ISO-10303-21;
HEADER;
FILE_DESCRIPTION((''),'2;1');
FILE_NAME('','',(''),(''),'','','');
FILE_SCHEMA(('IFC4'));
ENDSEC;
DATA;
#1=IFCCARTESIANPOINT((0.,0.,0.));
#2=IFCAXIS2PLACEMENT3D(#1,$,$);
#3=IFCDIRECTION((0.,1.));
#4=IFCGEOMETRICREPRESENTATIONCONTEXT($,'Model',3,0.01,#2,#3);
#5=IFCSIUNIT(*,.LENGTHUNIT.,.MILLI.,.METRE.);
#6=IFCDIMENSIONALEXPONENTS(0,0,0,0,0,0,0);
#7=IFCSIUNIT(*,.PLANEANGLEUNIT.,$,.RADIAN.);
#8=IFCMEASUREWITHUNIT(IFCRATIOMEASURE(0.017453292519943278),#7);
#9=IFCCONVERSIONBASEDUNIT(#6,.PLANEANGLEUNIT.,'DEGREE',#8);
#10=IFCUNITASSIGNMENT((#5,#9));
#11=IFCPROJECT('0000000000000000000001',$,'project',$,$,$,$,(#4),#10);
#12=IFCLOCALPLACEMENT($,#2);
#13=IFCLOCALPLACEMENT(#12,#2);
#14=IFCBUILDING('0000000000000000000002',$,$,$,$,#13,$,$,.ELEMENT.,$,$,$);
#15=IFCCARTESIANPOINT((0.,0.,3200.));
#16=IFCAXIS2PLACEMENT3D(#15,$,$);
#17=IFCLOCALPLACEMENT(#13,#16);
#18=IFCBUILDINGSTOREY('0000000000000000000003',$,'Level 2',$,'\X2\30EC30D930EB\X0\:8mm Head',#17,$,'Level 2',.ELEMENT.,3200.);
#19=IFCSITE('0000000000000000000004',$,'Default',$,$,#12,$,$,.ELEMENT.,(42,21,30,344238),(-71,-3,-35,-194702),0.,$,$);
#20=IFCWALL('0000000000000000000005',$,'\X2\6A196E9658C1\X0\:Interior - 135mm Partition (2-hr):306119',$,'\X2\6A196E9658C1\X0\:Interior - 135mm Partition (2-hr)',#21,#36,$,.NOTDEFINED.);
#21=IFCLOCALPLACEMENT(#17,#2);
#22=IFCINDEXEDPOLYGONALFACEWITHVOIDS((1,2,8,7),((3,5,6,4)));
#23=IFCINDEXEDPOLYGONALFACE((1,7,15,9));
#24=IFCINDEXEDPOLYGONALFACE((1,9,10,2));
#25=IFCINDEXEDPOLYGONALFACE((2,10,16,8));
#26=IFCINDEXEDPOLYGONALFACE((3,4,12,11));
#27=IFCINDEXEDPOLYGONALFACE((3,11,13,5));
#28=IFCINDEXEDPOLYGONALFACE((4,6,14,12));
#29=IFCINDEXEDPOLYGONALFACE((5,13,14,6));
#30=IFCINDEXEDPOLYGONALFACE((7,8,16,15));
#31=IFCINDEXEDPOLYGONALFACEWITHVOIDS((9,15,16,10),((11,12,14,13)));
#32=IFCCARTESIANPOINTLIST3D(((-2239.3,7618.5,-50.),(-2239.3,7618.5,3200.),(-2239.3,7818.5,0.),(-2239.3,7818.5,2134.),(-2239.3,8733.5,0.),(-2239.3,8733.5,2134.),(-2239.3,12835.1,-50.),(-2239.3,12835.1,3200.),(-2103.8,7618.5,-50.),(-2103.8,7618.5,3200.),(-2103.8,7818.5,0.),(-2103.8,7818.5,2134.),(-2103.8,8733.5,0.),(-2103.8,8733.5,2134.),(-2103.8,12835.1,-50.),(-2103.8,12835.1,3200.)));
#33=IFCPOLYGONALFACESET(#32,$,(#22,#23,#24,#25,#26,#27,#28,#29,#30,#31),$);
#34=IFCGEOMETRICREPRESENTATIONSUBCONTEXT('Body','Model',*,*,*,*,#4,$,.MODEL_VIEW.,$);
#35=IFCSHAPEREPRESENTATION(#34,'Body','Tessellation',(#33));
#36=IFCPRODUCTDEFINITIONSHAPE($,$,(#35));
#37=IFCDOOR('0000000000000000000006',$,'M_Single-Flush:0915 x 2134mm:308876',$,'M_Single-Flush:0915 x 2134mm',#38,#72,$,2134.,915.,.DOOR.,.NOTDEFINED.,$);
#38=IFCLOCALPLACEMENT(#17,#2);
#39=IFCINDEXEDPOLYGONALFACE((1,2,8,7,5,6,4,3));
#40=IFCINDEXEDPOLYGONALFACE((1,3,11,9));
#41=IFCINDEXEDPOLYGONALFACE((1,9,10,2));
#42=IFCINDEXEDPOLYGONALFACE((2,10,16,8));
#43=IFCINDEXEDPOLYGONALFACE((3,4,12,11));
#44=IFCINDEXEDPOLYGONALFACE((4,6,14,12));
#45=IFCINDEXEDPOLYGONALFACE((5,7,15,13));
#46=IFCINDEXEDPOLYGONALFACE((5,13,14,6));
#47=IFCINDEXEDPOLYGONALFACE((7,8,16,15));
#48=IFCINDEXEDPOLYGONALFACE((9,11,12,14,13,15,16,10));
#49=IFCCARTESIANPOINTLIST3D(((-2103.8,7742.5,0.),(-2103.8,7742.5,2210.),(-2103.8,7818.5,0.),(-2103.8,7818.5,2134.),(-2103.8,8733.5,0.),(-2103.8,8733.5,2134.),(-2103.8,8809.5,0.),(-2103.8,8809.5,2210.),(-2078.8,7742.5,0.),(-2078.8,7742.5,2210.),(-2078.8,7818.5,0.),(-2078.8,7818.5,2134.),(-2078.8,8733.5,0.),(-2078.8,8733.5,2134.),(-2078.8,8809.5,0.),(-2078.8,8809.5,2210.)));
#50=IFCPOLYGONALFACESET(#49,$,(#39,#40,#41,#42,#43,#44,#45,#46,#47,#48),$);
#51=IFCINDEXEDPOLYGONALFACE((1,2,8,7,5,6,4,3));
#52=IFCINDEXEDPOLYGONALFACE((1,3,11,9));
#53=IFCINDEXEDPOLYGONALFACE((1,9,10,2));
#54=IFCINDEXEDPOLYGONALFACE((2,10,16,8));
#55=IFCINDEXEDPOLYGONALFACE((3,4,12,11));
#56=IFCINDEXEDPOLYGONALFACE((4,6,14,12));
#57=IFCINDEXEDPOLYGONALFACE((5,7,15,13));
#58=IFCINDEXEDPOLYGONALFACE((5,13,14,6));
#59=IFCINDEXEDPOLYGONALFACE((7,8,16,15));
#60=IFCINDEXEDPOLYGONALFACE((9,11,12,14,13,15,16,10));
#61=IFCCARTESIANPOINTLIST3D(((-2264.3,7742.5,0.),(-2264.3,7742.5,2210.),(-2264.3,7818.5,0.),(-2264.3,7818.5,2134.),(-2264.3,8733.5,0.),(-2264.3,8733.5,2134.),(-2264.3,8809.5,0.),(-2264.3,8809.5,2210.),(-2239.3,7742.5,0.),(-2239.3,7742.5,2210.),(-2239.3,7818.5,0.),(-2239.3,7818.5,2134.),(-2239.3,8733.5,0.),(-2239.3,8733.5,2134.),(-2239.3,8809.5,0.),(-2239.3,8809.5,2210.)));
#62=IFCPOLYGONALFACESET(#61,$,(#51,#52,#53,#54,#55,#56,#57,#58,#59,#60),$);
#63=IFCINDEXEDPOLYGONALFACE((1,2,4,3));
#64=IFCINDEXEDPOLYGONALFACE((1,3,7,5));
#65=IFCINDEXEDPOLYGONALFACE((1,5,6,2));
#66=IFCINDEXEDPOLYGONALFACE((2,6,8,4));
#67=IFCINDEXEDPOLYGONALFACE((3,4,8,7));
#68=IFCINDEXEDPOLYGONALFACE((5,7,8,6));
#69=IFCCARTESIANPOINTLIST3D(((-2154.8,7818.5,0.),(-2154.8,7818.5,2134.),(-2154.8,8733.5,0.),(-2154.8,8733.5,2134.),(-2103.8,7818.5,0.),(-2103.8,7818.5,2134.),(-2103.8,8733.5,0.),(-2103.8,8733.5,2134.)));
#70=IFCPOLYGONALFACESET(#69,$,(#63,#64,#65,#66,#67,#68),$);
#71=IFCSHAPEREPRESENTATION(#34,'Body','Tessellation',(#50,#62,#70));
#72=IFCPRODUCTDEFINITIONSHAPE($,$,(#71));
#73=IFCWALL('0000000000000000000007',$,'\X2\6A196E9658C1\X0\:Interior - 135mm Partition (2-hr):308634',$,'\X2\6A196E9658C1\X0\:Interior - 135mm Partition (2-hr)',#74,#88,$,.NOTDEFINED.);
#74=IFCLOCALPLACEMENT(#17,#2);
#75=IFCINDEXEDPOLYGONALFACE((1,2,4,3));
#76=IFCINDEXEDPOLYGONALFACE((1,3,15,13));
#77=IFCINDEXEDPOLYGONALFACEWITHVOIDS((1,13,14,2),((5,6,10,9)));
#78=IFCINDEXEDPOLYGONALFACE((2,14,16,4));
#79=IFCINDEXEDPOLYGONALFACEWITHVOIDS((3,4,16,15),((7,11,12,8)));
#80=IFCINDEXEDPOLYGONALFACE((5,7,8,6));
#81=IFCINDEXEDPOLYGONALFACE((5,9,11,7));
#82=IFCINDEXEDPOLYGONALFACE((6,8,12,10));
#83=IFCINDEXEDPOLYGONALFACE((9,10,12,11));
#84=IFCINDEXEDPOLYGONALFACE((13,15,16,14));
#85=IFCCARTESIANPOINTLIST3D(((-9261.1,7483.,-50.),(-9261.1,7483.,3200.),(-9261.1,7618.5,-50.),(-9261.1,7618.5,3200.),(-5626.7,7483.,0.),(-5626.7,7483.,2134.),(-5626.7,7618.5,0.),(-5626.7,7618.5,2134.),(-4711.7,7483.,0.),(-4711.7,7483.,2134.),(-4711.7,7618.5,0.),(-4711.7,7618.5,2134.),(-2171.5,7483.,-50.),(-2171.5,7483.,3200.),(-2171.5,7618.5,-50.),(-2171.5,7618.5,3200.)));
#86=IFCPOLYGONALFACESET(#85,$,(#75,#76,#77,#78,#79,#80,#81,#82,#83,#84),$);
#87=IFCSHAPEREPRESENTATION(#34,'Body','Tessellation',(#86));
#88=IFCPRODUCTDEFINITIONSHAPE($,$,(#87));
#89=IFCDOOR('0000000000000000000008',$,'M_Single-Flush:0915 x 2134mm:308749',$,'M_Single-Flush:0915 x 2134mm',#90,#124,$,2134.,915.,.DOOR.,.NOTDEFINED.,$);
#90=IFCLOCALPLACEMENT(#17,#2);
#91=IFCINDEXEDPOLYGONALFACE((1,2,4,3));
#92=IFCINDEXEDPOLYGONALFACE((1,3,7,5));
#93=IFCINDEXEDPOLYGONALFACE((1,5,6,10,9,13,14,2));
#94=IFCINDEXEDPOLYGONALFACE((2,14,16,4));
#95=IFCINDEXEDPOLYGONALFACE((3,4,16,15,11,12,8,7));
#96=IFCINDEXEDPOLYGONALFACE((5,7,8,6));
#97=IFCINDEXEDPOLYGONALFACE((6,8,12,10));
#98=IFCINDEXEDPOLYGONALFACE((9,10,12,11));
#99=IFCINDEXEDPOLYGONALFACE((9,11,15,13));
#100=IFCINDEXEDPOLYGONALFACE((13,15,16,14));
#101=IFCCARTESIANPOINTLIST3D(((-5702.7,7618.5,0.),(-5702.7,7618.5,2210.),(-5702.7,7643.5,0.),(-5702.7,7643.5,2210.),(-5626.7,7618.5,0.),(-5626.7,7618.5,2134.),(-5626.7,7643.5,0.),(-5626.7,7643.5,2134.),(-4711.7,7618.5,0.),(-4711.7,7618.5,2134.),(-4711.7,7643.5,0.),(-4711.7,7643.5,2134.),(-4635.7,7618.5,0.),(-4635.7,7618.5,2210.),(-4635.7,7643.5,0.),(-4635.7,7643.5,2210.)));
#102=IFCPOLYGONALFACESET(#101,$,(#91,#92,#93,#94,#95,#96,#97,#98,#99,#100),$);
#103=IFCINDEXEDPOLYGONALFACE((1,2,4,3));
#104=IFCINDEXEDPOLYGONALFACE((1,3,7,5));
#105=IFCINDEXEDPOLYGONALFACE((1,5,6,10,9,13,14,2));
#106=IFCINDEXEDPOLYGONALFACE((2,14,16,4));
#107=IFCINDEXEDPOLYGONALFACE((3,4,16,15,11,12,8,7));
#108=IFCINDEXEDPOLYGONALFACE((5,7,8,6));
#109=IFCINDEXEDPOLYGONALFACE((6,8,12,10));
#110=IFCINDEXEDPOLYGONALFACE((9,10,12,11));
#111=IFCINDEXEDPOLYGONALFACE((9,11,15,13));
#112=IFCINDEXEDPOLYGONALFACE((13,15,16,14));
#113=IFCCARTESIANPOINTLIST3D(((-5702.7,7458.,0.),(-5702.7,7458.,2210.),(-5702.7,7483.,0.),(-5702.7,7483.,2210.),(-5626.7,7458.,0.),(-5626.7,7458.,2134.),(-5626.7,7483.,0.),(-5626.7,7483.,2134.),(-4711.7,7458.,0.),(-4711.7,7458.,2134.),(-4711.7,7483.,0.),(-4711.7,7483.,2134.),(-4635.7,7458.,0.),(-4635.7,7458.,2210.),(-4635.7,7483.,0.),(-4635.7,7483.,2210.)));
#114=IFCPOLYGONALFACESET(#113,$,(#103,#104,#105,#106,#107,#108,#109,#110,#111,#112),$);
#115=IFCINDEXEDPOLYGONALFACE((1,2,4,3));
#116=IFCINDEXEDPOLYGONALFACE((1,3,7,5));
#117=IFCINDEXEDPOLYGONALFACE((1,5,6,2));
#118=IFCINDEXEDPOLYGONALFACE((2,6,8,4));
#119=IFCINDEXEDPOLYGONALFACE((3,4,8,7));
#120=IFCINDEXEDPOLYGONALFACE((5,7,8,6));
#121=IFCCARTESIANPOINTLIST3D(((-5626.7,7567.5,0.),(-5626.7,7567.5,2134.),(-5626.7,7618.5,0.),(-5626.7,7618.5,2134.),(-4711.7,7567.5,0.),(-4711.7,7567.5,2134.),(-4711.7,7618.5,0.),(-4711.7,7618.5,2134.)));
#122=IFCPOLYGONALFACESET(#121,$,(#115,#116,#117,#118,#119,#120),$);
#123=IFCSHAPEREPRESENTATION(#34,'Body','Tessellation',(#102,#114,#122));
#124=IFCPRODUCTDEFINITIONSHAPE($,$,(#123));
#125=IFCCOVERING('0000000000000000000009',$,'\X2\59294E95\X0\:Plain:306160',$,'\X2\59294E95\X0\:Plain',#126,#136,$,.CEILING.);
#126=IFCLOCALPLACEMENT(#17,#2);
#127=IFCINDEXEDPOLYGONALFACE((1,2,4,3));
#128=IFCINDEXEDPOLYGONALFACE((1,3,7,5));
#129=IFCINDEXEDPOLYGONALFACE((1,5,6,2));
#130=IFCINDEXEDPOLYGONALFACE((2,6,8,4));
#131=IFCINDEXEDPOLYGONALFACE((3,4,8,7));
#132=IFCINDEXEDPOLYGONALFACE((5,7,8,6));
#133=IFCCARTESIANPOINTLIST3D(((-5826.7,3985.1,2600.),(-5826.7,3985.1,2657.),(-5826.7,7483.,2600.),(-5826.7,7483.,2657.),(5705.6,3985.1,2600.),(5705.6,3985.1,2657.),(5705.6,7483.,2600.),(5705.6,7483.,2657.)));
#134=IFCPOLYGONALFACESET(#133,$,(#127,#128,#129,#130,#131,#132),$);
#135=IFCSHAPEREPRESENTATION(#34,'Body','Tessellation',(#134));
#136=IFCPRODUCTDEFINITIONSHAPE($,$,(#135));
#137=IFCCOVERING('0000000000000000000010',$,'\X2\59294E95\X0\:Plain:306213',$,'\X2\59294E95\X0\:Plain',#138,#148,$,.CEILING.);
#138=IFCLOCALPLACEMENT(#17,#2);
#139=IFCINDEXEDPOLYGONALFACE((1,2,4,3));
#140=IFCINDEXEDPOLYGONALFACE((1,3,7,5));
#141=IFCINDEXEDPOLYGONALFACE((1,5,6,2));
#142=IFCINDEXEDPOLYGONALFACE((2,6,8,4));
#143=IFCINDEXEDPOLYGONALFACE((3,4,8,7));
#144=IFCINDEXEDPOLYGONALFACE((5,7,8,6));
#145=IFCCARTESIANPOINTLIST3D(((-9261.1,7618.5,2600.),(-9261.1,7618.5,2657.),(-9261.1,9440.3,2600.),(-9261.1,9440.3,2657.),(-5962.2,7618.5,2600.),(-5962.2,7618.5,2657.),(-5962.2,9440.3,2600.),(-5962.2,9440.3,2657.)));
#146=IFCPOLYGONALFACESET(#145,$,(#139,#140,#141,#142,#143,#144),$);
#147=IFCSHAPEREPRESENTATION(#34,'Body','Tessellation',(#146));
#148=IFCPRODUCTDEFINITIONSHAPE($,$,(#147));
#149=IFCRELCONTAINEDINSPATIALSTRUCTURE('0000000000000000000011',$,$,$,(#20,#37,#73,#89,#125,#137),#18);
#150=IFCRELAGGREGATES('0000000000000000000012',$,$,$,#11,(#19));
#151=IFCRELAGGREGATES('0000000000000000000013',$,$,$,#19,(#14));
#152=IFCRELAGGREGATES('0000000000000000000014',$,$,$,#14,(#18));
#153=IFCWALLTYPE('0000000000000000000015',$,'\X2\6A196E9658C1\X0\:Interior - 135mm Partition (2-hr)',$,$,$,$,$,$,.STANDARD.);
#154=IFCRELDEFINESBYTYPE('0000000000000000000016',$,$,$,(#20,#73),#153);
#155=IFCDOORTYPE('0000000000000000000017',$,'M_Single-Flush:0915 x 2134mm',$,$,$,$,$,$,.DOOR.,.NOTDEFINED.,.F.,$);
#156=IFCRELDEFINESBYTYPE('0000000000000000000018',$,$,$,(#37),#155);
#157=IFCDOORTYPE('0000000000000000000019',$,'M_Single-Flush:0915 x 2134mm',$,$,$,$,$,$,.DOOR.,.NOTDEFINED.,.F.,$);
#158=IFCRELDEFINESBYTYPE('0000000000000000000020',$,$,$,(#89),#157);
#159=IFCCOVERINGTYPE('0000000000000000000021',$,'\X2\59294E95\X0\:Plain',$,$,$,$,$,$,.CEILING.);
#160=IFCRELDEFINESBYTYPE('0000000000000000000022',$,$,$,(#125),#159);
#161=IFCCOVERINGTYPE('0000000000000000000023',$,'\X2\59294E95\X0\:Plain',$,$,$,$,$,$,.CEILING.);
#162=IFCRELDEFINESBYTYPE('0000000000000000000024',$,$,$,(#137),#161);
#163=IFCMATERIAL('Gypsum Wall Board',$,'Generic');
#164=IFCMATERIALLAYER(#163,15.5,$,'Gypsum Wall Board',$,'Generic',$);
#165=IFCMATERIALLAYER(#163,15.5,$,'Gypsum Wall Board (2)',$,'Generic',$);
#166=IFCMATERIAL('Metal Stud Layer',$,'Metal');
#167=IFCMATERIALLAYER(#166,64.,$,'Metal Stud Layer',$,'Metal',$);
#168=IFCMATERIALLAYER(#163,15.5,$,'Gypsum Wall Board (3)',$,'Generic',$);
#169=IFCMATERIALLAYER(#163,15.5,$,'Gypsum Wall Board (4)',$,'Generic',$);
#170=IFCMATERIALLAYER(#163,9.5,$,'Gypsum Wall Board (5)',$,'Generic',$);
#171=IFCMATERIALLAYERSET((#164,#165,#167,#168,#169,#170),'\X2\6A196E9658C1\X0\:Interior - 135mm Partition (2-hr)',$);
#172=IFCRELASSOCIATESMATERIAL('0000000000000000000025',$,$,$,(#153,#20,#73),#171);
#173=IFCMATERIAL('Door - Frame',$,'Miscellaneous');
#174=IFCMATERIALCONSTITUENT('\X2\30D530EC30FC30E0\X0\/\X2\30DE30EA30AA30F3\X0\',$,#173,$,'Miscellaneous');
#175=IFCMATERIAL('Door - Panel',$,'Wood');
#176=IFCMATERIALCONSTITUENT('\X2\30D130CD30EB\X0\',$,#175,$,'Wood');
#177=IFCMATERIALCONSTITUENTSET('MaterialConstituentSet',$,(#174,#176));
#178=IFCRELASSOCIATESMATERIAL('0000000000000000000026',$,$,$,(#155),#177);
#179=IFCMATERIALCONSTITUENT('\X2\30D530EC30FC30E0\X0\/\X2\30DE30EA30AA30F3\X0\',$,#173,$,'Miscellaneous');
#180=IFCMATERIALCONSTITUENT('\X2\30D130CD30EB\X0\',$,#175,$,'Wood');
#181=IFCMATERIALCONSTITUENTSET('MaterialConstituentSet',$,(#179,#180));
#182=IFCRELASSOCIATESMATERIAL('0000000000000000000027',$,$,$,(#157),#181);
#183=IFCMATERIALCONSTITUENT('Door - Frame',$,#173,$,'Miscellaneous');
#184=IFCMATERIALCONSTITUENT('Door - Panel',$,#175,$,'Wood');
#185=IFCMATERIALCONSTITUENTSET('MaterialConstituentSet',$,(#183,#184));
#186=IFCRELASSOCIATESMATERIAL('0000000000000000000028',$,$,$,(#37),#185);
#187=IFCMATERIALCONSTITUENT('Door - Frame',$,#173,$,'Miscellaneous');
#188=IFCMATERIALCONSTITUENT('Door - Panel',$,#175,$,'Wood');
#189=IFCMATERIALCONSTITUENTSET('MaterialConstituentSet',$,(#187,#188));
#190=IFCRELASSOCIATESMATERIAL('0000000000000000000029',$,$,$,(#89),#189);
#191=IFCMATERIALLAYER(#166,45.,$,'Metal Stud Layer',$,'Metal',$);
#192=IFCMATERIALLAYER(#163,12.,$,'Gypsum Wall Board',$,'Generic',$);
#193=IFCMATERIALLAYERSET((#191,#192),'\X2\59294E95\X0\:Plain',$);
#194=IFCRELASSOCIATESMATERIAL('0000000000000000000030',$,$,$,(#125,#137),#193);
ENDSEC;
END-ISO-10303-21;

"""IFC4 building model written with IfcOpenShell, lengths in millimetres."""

from ifc_helpers import new_model, entity, si_unit, converted_unit, direction, frame, frame_2d, origin, place, context, subcontext, project, spatial, polyline, rectangle, outline, extrude, source, transform, mapped, material, layer, layer_set, layer_usage, constituent, constituent_set, type_object, type_shapes, element, fill, save


model = new_model("IFC4")

# Units and contexts
model_context = context("Model", 3, precision=0.01, world=origin(), true_north=direction((0.0, 1.0)))
body_context = subcontext(model_context, "Body", "Model", "MODEL_VIEW")
ifc_project = project(units=[si_unit("LENGTHUNIT", "METRE", prefix="MILLI"), converted_unit("PLANEANGLEUNIT", "DEGREE", entity("IfcRatioMeasure", 0.017453292519943278), si_unit("PLANEANGLEUNIT", "RADIAN"), dimensions=[0, 0, 0, 0, 0, 0, 0])], contexts=[model_context])

# Site, building, storey
site_placement = place(None, origin())
site = spatial("IfcSite", under=ifc_project, at=site_placement, Name="Default", CompositionType="ELEMENT", RefLatitude=(42, 21, 30, 344238), RefLongitude=(-71, -3, -35, -194702), RefElevation=0.0)
building_placement = place(site_placement, origin())
building = spatial("IfcBuilding", under=site, at=building_placement, CompositionType="ELEMENT")
storey_placement = place(building_placement, frame((0.0, 0.0, 3200.0)))
storey = spatial("IfcBuildingStorey", under=building, at=storey_placement, Name="Level 2", ObjectType="レベル:8mm Head", LongName="Level 2", CompositionType="ELEMENT", Elevation=3200.0)

# Shared definitions
ifc_material_1 = material(Name="Gypsum Wall Board", Category="Generic")
ifc_layer_1 = layer(ifc_material_1, 15.5, Name="Gypsum Wall Board", Category="Generic")
ifc_layer_2 = layer(ifc_material_1, 15.5, Name="Gypsum Wall Board (2)", Category="Generic")
ifc_material_2 = material(Name="Metal Stud Layer", Category="Metal")
ifc_layer_3 = layer(ifc_material_2, 64.0, Name="Metal Stud Layer", Category="Metal")
ifc_layer_4 = layer(ifc_material_1, 15.5, Name="Gypsum Wall Board (3)", Category="Generic")
ifc_layer_5 = layer(ifc_material_1, 15.5, Name="Gypsum Wall Board (4)", Category="Generic")
ifc_layer_6 = layer(ifc_material_1, 9.5, Name="Gypsum Wall Board (5)", Category="Generic")
ifc_layer_set_1 = layer_set([ifc_layer_1, ifc_layer_2, ifc_layer_3, ifc_layer_4, ifc_layer_5, ifc_layer_6], Name="標準壁:Interior - 135mm Partition (2-hr)")
wall_type = type_object("IfcWallType", Name="標準壁:Interior - 135mm Partition (2-hr)", PredefinedType="STANDARD", material=ifc_layer_set_1)
ifc_material_3 = material(Name="Door - Frame", Category="Miscellaneous")
ifc_material_4 = material(Name="Door - Panel", Category="Wood")
ifc_constituent_1 = constituent(ifc_material_3, Name="フレーム/マリオン", Category="Miscellaneous")
ifc_constituent_2 = constituent(ifc_material_4, Name="パネル", Category="Wood")
ifc_constituent_set_1 = constituent_set(constituents=[ifc_constituent_1, ifc_constituent_2], Name="MaterialConstituentSet")
door_type_1 = type_object("IfcDoorType", Name="M_Single-Flush:0915 x 2134mm", OperationType="NOTDEFINED", ParameterTakesPrecedence=False, PredefinedType="DOOR", material=ifc_constituent_set_1)
shared_shape_1 = source(origin(), body_context, "Body", "SweptSolid", [
    extrude(outline(polyline([(-533.5, -1124.0), (533.5, -1124.0), (533.5, 1086.0), (457.5, 1086.0), (457.5, -1048.0), (-457.5, -1048.0), (-457.5, 1086.0), (-533.5, 1086.0), (-533.5, -1124.0)])), frame((457.5, 135.5, 1086.0), z_axis=(0.0, 1.0, 0.0), x_axis=(1.0, 0.0, 0.0)), (0.0, 0.0, 1.0), 25.0),
    extrude(outline(polyline([(-1124.0, -533.5), (1086.0, -533.5), (1086.0, -457.5), (-1048.0, -457.5), (-1048.0, 457.5), (1086.0, 457.5), (1086.0, 533.5), (-1124.0, 533.5), (-1124.0, -533.5)])), frame((457.5, -25.0, 1086.0), z_axis=(0.0, 1.0, 0.0), x_axis=(0.0, 0.0, -1.0)), (0.0, 0.0, 1.0), 25.0),
    extrude(rectangle(XDim=51.0, YDim=915.0, at=frame_2d((0.0, 0.0), x_axis=(1.0, 0.0))), frame((457.5, 110.0, 0.0), z_axis=(0.0, 0.0, 1.0), x_axis=(0.0, 1.0, 0.0)), (0.0, 0.0, 1.0), 2134.0),
])
type_shapes(door_type_1, [shared_shape_1])
ifc_constituent_3 = constituent(ifc_material_3, Name="フレーム/マリオン", Category="Miscellaneous")
ifc_constituent_4 = constituent(ifc_material_4, Name="パネル", Category="Wood")
ifc_constituent_set_2 = constituent_set(constituents=[ifc_constituent_3, ifc_constituent_4], Name="MaterialConstituentSet")
door_type_2 = type_object("IfcDoorType", Name="M_Single-Flush:0915 x 2134mm", OperationType="NOTDEFINED", ParameterTakesPrecedence=False, PredefinedType="DOOR", material=ifc_constituent_set_2)
shared_shape_2 = source(origin(), body_context, "Body", "SweptSolid", [
    extrude(outline(polyline([(-533.5, -1124.0), (533.5, -1124.0), (533.5, 1086.0), (457.5, 1086.0), (457.5, -1048.0), (-457.5, -1048.0), (-457.5, 1086.0), (-533.5, 1086.0), (-533.5, -1124.0)])), frame((457.5, 160.5, 1086.0), z_axis=(0.0, -1.0, 0.0), x_axis=(-1.0, 0.0, 0.0)), (0.0, 0.0, 1.0), 25.0),
    extrude(outline(polyline([(-1124.0, -533.5), (1086.0, -533.5), (1086.0, -457.5), (-1048.0, -457.5), (-1048.0, 457.5), (1086.0, 457.5), (1086.0, 533.5), (-1124.0, 533.5), (-1124.0, -533.5)])), frame((457.5, 0.0, 1086.0), z_axis=(0.0, -1.0, 0.0), x_axis=(0.0, 0.0, -1.0)), (0.0, 0.0, 1.0), 25.0),
    extrude(rectangle(XDim=915.0, YDim=51.0, at=frame_2d((0.0, 0.0), x_axis=(1.0, 0.0))), frame((457.5, 110.0, 0.0)), (0.0, 0.0, 1.0), 2134.0),
])
type_shapes(door_type_2, [shared_shape_2])

# Walls, openings, doors
ifc_layer_usage_1 = layer_usage(ifc_layer_set_1, "AXIS2", "NEGATIVE", 67.8)
wall_1_placement = place(storey_placement, frame((-2171.5, 12835.1, -50.0), z_axis=(0.0, 0.0, 1.0), x_axis=(0.0, -1.0, 0.0)))
wall_1 = element("IfcWall", 1, at=wall_1_placement, inside=storey, type_object=wall_type, material=ifc_layer_usage_1, Name="標準壁:Interior - 135mm Partition (2-hr):306119", ObjectType="標準壁:Interior - 135mm Partition (2-hr)", PredefinedType="NOTDEFINED", context=body_context, shape_type="SweptSolid", body=[
    extrude(rectangle(XDim=5216.6, YDim=135.5, at=frame_2d((2608.3, 0.0), x_axis=(-1.0, 0.0))), origin(), (0.0, 0.0, 1.0), 3250.0),
])
opening_1_placement = place(wall_1_placement, frame((4101.6, -67.8, 50.0)))
opening_1 = element("IfcOpeningElement", 2, at=opening_1_placement, cuts=wall_1, PredefinedType="OPENING", context=body_context, shape_type="SweptSolid", body=[
    extrude(rectangle(XDim=915.0, YDim=2134.0, at=frame_2d((1067.0, 457.5), x_axis=(0.0, 1.0))), frame((0.0, 0.0, 0.0), z_axis=(0.0, 1.0, 0.0), x_axis=(0.0, 0.0, 1.0)), (0.0, 0.0, 1.0), 135.5),
])
ifc_constituent_5 = constituent(ifc_material_3, Name="Door - Frame", Category="Miscellaneous")
ifc_constituent_6 = constituent(ifc_material_4, Name="Door - Panel", Category="Wood")
ifc_constituent_set_3 = constituent_set(constituents=[ifc_constituent_5, ifc_constituent_6], Name="MaterialConstituentSet")
door_1_placement = place(opening_1_placement, origin())
door_1 = element("IfcDoor", 3, at=door_1_placement, inside=storey, type_object=door_type_1, material=ifc_constituent_set_3, Name="M_Single-Flush:0915 x 2134mm:308876", ObjectType="M_Single-Flush:0915 x 2134mm", OperationType="NOTDEFINED", OverallHeight=2134.0, OverallWidth=915.0, PredefinedType="DOOR", context=body_context, shape_type="MappedRepresentation", body=[
    mapped(shared_shape_1, transform((0.0, 0.0, 0.0), scale=1.0)),
])
fill(opening_1, door_1)
ifc_layer_usage_2 = layer_usage(ifc_layer_set_1, "AXIS2", "NEGATIVE", 67.8)
wall_2_placement = place(storey_placement, frame((-2171.5, 7550.8, -50.0), z_axis=(0.0, 0.0, 1.0), x_axis=(-1.0, 0.0, 0.0)))
wall_2 = element("IfcWall", 4, at=wall_2_placement, inside=storey, type_object=wall_type, material=ifc_layer_usage_2, Name="標準壁:Interior - 135mm Partition (2-hr):308634", ObjectType="標準壁:Interior - 135mm Partition (2-hr)", PredefinedType="NOTDEFINED", context=body_context, shape_type="SweptSolid", body=[
    extrude(rectangle(XDim=7089.6, YDim=135.5, at=frame_2d((3544.8, 0.0), x_axis=(-1.0, 0.0))), origin(), (0.0, 0.0, 1.0), 3250.0),
])
opening_2_placement = place(wall_2_placement, frame((3455.2, 67.7, 50.0)))
opening_2 = element("IfcOpeningElement", 5, at=opening_2_placement, cuts=wall_2, PredefinedType="OPENING", context=body_context, shape_type="SweptSolid", body=[
    extrude(rectangle(XDim=915.0, YDim=2134.0, at=frame_2d((1067.0, 457.5), x_axis=(0.0, -1.0))), frame((0.0, 0.0, 0.0), z_axis=(0.0, -1.0, 0.0), x_axis=(0.0, 0.0, 1.0)), (0.0, 0.0, 1.0), 135.5),
])
ifc_constituent_7 = constituent(ifc_material_3, Name="Door - Frame", Category="Miscellaneous")
ifc_constituent_8 = constituent(ifc_material_4, Name="Door - Panel", Category="Wood")
ifc_constituent_set_4 = constituent_set(constituents=[ifc_constituent_7, ifc_constituent_8], Name="MaterialConstituentSet")
door_2_placement = place(opening_2_placement, frame((0.0, 0.0, 0.0), z_axis=(0.0, 0.0, 1.0), x_axis=(-1.0, 0.0, 0.0)))
door_2 = element("IfcDoor", 6, at=door_2_placement, inside=storey, type_object=door_type_2, material=ifc_constituent_set_4, Name="M_Single-Flush:0915 x 2134mm:308749", ObjectType="M_Single-Flush:0915 x 2134mm", OperationType="NOTDEFINED", OverallHeight=2134.0, OverallWidth=915.0, PredefinedType="DOOR", context=body_context, shape_type="MappedRepresentation", body=[
    mapped(shared_shape_2, transform((0.0, 0.0, 0.0), scale=1.0)),
])
fill(opening_2, door_2)

# Coverings
ifc_layer_7 = layer(ifc_material_2, 45.0, Name="Metal Stud Layer", Category="Metal")
ifc_layer_8 = layer(ifc_material_1, 12.0, Name="Gypsum Wall Board", Category="Generic")
ifc_layer_set_2 = layer_set([ifc_layer_7, ifc_layer_8], Name="天井:Plain")
ifc_layer_usage_3 = layer_usage(ifc_layer_set_2, "AXIS3", "POSITIVE", 0.0)
covering_type_1 = type_object("IfcCoveringType", Name="天井:Plain", PredefinedType="CEILING")
covering_1_placement = place(storey_placement, frame((-5826.7, 3985.1, 2600.0)))
element("IfcCovering", 7, at=covering_1_placement, inside=storey, type_object=covering_type_1, material=ifc_layer_usage_3, Name="天井:Plain:306160", ObjectType="天井:Plain", PredefinedType="CEILING", context=body_context, shape_type="SweptSolid", body=[
    extrude(rectangle(XDim=11532.2, YDim=3497.9, at=frame_2d((-455.7, 0.0), x_axis=(1.0, 0.0))), frame((5310.4, 1749.0, 0.0), z_axis=(0.0, 0.0, 1.0), x_axis=(-1.0, 0.0, 0.0)), (0.0, 0.0, 1.0), 57.0),
])
ifc_layer_usage_4 = layer_usage(ifc_layer_set_2, "AXIS3", "POSITIVE", 0.0)
covering_type_2 = type_object("IfcCoveringType", Name="天井:Plain", PredefinedType="CEILING")
covering_2_placement = place(storey_placement, frame((-9261.1, 7618.5, 2600.0)))
element("IfcCovering", 8, at=covering_2_placement, inside=storey, type_object=covering_type_2, material=ifc_layer_usage_4, Name="天井:Plain:306213", ObjectType="天井:Plain", PredefinedType="CEILING", context=body_context, shape_type="SweptSolid", body=[
    extrude(rectangle(XDim=3298.9, YDim=1821.8, at=frame_2d((0.0, 0.0), x_axis=(1.0, 0.0))), frame((1649.5, 910.9, 0.0)), (0.0, 0.0, 1.0), 57.0),
])

save(model, "model.ifc")
